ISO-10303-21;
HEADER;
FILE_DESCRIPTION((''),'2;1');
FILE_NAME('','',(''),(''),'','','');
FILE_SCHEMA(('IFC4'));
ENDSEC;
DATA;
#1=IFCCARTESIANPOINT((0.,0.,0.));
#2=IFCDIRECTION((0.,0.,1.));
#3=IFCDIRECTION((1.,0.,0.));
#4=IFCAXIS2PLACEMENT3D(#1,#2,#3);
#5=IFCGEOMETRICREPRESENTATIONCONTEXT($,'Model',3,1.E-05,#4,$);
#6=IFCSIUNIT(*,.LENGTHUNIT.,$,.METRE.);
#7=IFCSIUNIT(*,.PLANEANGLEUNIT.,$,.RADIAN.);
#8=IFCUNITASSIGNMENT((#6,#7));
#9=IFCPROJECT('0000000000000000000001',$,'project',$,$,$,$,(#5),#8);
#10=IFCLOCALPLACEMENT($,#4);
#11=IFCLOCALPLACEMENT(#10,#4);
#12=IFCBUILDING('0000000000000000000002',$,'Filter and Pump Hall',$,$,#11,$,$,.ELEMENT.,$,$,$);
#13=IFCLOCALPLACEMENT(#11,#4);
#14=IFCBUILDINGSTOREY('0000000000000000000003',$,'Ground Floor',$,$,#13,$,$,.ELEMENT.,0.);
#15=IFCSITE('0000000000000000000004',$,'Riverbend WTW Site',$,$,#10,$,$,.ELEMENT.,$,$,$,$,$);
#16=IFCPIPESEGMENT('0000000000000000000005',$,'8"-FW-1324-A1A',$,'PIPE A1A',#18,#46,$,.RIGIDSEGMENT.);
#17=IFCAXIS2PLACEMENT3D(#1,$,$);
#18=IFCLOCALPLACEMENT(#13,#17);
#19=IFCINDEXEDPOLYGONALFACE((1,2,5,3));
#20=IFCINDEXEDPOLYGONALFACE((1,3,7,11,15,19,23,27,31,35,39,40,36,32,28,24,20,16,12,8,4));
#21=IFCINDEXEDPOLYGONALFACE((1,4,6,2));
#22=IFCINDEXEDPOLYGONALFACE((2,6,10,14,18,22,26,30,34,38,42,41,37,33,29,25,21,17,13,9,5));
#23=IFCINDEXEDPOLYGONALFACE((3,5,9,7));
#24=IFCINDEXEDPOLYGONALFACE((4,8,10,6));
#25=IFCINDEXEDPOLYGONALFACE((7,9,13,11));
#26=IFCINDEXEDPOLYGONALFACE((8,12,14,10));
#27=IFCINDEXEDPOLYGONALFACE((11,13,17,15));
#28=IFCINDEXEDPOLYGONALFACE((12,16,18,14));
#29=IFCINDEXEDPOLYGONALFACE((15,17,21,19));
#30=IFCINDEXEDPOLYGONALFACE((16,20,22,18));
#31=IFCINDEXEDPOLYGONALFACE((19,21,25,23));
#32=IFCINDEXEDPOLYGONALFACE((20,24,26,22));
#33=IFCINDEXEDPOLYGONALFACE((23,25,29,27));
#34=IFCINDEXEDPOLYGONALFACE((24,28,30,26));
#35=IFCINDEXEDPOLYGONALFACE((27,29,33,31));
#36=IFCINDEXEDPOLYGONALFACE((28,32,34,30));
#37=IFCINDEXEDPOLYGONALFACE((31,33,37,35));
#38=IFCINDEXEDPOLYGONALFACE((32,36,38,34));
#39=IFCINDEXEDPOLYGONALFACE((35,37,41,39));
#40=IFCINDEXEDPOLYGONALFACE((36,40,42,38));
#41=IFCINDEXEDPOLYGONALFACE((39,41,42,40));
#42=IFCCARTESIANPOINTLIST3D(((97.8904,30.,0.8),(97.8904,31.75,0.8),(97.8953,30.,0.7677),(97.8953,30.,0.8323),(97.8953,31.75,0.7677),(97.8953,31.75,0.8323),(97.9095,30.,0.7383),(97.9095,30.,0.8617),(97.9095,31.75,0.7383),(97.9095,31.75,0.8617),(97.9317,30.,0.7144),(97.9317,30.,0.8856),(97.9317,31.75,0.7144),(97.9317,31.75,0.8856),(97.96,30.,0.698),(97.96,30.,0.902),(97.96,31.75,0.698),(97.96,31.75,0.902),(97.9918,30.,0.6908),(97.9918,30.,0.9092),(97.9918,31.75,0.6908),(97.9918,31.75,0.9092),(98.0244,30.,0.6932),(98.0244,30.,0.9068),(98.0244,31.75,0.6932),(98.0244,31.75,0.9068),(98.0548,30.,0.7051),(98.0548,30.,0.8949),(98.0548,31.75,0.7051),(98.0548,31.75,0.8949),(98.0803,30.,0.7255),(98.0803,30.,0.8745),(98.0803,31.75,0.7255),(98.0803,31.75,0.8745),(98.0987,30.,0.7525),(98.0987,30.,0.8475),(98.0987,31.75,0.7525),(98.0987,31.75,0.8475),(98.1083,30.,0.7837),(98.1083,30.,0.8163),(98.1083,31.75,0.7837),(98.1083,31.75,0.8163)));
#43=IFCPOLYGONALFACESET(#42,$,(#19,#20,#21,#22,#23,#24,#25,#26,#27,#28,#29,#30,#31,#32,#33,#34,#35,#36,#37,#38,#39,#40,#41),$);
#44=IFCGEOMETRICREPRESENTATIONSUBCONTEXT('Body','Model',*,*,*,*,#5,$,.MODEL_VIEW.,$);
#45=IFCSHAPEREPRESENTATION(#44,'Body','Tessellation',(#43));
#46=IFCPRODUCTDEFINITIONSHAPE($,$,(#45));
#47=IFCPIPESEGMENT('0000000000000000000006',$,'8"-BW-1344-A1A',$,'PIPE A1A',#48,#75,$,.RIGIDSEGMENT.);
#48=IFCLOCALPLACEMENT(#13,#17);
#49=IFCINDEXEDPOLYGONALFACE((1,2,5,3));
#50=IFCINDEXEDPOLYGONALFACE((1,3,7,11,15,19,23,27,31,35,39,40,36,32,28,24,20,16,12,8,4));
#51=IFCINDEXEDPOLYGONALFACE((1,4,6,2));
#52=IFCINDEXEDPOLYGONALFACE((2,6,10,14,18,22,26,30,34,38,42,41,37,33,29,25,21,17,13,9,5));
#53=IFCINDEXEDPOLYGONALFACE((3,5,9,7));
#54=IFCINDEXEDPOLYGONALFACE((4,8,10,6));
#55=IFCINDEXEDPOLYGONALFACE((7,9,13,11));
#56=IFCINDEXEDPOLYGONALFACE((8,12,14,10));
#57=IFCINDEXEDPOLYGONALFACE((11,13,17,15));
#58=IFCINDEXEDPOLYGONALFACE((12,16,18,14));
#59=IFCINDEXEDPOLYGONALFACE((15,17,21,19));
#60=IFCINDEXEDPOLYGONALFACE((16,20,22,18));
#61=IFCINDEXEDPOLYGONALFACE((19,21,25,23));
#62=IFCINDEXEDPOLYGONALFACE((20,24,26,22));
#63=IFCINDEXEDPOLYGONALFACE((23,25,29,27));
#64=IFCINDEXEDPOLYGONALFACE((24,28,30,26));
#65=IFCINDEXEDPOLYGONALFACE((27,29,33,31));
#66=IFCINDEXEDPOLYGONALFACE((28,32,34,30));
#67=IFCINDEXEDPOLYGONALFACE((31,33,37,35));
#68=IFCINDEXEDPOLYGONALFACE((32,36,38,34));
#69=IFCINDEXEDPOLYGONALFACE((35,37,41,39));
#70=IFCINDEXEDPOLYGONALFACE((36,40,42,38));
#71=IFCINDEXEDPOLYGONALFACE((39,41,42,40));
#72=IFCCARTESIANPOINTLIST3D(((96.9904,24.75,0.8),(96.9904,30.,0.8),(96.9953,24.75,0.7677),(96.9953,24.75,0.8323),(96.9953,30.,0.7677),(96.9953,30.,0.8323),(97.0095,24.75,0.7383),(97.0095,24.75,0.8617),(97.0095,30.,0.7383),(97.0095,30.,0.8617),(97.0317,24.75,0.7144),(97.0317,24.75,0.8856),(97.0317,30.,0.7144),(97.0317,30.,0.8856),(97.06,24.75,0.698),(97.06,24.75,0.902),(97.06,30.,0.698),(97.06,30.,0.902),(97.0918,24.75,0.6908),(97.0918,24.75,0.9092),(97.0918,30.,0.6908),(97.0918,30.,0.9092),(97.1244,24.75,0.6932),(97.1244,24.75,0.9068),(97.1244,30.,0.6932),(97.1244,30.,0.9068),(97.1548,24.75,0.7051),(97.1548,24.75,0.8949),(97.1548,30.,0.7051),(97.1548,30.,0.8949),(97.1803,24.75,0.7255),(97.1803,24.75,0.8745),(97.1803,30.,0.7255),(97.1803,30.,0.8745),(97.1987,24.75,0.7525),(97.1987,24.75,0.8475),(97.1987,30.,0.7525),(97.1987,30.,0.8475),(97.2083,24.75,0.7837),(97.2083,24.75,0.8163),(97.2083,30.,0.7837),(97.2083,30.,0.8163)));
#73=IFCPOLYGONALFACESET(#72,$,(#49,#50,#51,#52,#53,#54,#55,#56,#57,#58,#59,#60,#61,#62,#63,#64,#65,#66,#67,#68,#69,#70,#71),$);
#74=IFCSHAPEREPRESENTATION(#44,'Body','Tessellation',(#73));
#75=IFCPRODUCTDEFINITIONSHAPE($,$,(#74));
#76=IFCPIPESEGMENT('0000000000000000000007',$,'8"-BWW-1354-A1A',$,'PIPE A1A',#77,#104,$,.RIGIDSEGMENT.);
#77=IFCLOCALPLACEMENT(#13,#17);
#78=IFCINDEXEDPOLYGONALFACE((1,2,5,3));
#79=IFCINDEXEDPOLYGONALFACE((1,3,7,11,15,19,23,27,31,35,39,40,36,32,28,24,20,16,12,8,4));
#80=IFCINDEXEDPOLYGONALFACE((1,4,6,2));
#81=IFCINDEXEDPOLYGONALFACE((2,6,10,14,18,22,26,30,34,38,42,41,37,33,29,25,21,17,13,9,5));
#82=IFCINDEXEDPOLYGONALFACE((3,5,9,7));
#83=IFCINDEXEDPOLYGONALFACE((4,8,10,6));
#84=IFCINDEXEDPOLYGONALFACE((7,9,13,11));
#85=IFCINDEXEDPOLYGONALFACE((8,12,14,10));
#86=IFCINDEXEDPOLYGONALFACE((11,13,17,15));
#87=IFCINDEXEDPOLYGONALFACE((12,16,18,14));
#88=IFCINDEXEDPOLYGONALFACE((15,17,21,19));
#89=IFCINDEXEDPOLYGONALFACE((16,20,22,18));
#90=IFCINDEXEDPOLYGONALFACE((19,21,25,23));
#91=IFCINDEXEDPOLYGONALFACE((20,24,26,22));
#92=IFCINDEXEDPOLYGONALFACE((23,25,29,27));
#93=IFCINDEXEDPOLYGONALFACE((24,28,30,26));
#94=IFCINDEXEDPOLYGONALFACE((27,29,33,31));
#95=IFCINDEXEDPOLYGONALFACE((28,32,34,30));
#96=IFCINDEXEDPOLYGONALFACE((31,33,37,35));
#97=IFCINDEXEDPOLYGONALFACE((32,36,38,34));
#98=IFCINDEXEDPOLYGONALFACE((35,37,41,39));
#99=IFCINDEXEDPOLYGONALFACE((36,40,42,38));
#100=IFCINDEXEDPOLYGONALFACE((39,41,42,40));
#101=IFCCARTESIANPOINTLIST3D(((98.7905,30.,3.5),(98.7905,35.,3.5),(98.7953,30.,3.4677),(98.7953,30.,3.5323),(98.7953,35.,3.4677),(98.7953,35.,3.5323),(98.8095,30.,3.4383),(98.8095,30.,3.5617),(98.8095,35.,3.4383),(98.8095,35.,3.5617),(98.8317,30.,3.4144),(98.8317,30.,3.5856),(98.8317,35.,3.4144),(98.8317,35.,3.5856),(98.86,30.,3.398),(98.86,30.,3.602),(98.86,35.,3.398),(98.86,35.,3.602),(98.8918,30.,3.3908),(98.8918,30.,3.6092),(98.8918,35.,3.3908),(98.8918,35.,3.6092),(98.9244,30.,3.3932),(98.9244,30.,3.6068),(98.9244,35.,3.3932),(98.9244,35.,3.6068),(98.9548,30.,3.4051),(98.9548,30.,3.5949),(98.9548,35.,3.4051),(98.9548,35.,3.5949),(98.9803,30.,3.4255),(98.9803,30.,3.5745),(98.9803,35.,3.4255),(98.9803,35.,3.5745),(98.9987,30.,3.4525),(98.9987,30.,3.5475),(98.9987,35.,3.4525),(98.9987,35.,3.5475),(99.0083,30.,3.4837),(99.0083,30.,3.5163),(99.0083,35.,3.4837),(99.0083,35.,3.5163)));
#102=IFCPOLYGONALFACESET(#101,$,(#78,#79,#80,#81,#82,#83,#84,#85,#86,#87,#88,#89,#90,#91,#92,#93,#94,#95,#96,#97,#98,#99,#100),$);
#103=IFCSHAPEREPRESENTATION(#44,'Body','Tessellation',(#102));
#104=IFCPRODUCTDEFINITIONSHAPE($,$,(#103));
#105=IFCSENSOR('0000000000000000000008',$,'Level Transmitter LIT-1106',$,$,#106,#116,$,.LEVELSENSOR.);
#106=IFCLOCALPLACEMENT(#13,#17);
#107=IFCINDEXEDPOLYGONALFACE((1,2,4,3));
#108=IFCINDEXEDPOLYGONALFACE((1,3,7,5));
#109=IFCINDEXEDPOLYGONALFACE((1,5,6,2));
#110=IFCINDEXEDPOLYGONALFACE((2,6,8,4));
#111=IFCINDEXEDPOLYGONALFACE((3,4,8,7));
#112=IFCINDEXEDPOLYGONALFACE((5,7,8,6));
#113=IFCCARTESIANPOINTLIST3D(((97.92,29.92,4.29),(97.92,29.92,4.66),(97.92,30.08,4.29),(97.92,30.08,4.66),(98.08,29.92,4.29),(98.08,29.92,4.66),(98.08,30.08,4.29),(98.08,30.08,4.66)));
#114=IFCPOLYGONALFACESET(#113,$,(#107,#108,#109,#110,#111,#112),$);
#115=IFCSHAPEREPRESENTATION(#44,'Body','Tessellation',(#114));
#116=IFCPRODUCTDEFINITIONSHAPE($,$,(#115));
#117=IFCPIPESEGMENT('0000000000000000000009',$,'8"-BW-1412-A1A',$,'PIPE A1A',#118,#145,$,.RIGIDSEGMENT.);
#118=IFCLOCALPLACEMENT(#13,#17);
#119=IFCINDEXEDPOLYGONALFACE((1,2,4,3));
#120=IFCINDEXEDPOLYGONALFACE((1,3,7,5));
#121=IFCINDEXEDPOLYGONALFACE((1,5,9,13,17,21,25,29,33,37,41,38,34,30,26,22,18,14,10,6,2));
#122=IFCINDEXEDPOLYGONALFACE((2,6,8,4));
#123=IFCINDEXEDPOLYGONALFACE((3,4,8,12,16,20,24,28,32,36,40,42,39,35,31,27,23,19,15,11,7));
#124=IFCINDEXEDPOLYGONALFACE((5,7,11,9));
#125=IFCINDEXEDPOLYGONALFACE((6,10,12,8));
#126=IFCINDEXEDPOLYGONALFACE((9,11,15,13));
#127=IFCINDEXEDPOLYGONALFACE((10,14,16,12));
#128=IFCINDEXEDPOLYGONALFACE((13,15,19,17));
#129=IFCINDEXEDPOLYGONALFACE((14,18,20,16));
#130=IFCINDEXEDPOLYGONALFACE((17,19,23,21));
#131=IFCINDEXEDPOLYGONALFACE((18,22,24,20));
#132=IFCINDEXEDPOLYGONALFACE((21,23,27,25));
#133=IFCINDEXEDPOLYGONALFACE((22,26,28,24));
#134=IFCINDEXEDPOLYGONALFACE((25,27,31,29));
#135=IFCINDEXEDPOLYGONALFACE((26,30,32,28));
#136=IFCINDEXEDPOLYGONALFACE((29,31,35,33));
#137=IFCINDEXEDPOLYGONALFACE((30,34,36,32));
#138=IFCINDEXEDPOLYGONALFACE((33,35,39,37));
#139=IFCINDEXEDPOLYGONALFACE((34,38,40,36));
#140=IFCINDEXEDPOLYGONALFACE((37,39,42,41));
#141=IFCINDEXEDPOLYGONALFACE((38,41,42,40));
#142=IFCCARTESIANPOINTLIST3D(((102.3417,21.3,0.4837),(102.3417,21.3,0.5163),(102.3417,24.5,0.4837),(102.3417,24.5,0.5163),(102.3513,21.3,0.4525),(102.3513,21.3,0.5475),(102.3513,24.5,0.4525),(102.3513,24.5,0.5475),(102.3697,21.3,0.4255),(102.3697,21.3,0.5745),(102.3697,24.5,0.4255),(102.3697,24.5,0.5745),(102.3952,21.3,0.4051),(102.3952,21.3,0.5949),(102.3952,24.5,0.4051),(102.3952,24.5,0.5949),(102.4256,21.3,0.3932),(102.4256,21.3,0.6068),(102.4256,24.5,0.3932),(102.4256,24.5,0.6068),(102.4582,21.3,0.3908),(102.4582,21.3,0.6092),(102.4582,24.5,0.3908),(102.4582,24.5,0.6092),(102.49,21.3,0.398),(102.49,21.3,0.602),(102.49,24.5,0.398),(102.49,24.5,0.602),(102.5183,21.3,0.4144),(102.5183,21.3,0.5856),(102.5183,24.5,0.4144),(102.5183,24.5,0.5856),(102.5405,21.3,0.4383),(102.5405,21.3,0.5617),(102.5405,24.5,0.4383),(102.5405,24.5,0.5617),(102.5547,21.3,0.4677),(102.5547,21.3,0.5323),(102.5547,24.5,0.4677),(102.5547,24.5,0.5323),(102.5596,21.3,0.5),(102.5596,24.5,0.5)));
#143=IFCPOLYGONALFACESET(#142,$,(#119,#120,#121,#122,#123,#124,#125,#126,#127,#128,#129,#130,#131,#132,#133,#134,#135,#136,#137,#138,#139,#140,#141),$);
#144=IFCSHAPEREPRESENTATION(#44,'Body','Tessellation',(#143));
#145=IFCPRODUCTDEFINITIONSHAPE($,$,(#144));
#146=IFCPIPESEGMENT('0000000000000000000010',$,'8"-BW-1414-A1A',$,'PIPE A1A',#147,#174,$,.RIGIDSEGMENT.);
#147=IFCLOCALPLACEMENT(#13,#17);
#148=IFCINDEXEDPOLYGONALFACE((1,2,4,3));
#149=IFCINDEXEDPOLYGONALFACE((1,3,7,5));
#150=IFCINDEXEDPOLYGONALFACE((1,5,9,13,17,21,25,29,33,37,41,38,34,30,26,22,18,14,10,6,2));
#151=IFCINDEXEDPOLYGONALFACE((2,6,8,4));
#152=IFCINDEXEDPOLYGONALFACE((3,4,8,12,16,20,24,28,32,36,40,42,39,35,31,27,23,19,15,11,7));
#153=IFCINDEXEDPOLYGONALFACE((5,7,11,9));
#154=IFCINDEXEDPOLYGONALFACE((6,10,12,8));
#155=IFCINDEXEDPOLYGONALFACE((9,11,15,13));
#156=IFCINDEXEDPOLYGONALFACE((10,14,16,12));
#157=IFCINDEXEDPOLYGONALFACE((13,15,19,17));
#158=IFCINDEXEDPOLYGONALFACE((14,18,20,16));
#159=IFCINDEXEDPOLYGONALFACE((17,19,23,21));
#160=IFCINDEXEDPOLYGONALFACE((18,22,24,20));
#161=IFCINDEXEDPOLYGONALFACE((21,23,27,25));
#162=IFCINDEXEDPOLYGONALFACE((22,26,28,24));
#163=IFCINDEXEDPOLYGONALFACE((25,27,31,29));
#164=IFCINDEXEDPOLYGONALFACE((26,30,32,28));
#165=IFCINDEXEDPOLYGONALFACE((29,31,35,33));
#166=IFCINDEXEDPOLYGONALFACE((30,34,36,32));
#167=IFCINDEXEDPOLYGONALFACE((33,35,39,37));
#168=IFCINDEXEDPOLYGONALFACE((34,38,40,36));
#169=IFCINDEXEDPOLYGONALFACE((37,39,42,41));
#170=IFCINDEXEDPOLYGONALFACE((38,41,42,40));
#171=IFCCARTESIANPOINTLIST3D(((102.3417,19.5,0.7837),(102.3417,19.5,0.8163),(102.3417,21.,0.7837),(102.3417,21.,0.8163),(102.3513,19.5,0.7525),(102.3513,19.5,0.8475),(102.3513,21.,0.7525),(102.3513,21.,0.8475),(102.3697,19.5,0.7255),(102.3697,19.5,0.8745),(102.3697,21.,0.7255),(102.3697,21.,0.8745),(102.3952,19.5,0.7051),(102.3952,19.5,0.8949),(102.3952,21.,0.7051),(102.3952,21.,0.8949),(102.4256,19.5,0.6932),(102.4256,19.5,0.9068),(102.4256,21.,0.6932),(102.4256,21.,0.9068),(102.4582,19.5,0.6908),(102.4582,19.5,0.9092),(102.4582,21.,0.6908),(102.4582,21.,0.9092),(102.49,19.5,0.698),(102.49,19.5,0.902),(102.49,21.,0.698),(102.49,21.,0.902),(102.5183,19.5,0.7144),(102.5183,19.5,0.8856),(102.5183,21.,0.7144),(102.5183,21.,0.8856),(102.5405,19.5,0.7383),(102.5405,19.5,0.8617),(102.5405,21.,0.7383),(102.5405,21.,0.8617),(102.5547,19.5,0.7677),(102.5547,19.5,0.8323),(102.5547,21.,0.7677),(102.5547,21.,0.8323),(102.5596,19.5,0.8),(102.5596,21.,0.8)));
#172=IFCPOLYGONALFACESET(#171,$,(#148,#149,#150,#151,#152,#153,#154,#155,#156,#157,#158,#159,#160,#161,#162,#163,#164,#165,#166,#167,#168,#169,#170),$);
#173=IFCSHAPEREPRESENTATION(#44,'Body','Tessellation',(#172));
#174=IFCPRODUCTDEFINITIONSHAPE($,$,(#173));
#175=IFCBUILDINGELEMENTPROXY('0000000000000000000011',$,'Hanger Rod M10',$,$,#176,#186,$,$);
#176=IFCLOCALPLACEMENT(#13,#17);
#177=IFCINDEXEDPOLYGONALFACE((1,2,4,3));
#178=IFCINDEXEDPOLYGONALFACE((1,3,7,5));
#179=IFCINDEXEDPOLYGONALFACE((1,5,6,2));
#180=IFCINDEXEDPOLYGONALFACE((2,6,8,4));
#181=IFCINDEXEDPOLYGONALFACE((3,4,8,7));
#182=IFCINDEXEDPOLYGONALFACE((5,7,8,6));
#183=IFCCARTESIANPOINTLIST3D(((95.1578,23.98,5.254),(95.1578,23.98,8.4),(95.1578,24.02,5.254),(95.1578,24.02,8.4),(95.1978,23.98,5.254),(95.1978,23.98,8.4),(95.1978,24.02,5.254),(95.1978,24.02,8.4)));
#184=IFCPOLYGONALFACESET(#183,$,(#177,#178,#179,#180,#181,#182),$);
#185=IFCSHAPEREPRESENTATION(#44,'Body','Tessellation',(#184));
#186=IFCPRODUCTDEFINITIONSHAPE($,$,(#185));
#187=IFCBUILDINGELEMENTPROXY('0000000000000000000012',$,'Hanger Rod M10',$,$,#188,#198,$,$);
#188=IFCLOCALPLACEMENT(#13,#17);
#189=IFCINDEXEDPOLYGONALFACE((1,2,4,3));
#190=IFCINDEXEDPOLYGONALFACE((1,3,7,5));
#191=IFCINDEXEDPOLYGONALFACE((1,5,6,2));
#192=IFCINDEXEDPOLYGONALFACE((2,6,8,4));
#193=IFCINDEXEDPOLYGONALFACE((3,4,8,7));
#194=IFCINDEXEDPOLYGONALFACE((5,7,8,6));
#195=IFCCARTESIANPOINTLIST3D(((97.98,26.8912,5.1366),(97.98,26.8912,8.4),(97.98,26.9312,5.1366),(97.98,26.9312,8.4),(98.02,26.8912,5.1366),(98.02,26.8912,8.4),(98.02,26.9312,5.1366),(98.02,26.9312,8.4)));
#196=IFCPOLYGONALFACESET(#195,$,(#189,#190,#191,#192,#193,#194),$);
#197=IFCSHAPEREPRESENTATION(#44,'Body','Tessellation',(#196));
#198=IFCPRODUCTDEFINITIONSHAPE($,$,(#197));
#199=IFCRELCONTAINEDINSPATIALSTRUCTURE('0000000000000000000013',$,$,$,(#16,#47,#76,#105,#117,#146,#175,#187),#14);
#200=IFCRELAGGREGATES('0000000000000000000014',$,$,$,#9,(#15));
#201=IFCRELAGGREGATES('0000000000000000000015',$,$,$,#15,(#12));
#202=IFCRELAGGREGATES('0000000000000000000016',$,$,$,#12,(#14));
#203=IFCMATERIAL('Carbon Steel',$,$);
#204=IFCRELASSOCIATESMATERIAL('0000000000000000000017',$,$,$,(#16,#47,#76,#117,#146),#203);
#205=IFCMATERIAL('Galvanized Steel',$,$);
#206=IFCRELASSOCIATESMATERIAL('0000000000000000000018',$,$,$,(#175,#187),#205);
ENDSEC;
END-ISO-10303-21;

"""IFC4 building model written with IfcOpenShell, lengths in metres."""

from ifc_helpers import new_model, si_unit, frame, origin_with_axes, origin_2d, place, context, subcontext, project, spatial, rectangle, circle, extrude, material, element, save


model = new_model("IFC4")

# Units and contexts
model_context = context("Model", 3, precision=1e-05, world=origin_with_axes())
body_context = subcontext(model_context, "Body", "Model", "MODEL_VIEW")
ifc_project = project(units=[si_unit("LENGTHUNIT", "METRE"), si_unit("PLANEANGLEUNIT", "RADIAN")], contexts=[model_context])

# Site, building, storey
site_placement = place(None, origin_with_axes())
site = spatial("IfcSite", under=ifc_project, at=site_placement, Name="Riverbend WTW Site", CompositionType="ELEMENT")
building_placement = place(site_placement, origin_with_axes())
building = spatial("IfcBuilding", under=site, at=building_placement, Name="Filter and Pump Hall", CompositionType="ELEMENT")
storey_placement = place(building_placement, origin_with_axes())
storey = spatial("IfcBuildingStorey", under=building, at=storey_placement, Name="Ground Floor", CompositionType="ELEMENT", Elevation=0.0)

# Shared definitions
ifc_material_1 = material(Name="Carbon Steel")

# Pipe segments
pipe_segment_1_placement = place(None, frame((98.0, 30.0, 0.8), z_axis=(0.0, 0.0, 1.0), x_axis=(1.0, 0.0, 0.0)))
element("IfcPipeSegment", 1, at=pipe_segment_1_placement, inside=storey, material=ifc_material_1, Name="8\"-FW-1324-A1A", ObjectType="PIPE A1A", PredefinedType="RIGIDSEGMENT", context=body_context, shape_type="SweptSolid", body=[
    extrude(circle(Radius=0.1095, at=origin_2d()), frame((0.0, 0.0, 0.0), z_axis=(0.0, 1.0, 0.0), x_axis=(-1.0, 0.0, 0.0)), (0.0, 0.0, 1.0), 1.75),
])
pipe_segment_2_placement = place(None, frame((97.1, 24.75, 0.8), z_axis=(0.0, 0.0, 1.0), x_axis=(1.0, 0.0, 0.0)))
element("IfcPipeSegment", 2, at=pipe_segment_2_placement, inside=storey, material=ifc_material_1, Name="8\"-BW-1344-A1A", ObjectType="PIPE A1A", PredefinedType="RIGIDSEGMENT", context=body_context, shape_type="SweptSolid", body=[
    extrude(circle(Radius=0.1095, at=origin_2d()), frame((0.0, 0.0, 0.0), z_axis=(0.0, 1.0, 0.0), x_axis=(-1.0, 0.0, 0.0)), (0.0, 0.0, 1.0), 5.25),
])
pipe_segment_3_placement = place(None, frame((98.9, 30.0, 3.5), z_axis=(0.0, 0.0, 1.0), x_axis=(1.0, 0.0, 0.0)))
element("IfcPipeSegment", 3, at=pipe_segment_3_placement, inside=storey, material=ifc_material_1, Name="8\"-BWW-1354-A1A", ObjectType="PIPE A1A", PredefinedType="RIGIDSEGMENT", context=body_context, shape_type="SweptSolid", body=[
    extrude(circle(Radius=0.1095, at=origin_2d()), frame((0.0, 0.0, 0.0), z_axis=(0.0, 1.0, 0.0), x_axis=(-1.0, 0.0, 0.0)), (0.0, 0.0, 1.0), 5.0),
])

# Sensor
sensor_1_placement = place(None, frame((98.0, 30.0, 4.475), z_axis=(0.0, 0.0, 1.0), x_axis=(1.0, 0.0, 0.0)))
element("IfcSensor", 4, at=sensor_1_placement, inside=storey, Name="Level Transmitter LIT-1106", PredefinedType="LEVELSENSOR", context=body_context, shape_type="SweptSolid", body=[
    extrude(rectangle(XDim=0.16, YDim=0.16, at=origin_2d()), frame((0.0, 0.0, -0.185), z_axis=(0.0, 0.0, 1.0), x_axis=(1.0, 0.0, 0.0)), (0.0, 0.0, 1.0), 0.37),
])

# Pipe segments
pipe_segment_4_placement = place(None, frame((102.45, 24.5, 0.5), z_axis=(0.0, 0.0, 1.0), x_axis=(1.0, 0.0, 0.0)))
element("IfcPipeSegment", 5, at=pipe_segment_4_placement, inside=storey, material=ifc_material_1, Name="8\"-BW-1412-A1A", ObjectType="PIPE A1A", PredefinedType="RIGIDSEGMENT", context=body_context, shape_type="SweptSolid", body=[
    extrude(circle(Radius=0.1095, at=origin_2d()), frame((0.0, 0.0, 0.0), z_axis=(0.0, -1.0, 0.0), x_axis=(1.0, 0.0, 0.0)), (0.0, 0.0, 1.0), 3.2),
])
pipe_segment_5_placement = place(None, frame((102.45, 21.0, 0.8), z_axis=(0.0, 0.0, 1.0), x_axis=(1.0, 0.0, 0.0)))
element("IfcPipeSegment", 6, at=pipe_segment_5_placement, inside=storey, material=ifc_material_1, Name="8\"-BW-1414-A1A", ObjectType="PIPE A1A", PredefinedType="RIGIDSEGMENT", context=body_context, shape_type="SweptSolid", body=[
    extrude(circle(Radius=0.1095, at=origin_2d()), frame((0.0, 0.0, 0.0), z_axis=(0.0, -1.0, 0.0), x_axis=(1.0, 0.0, 0.0)), (0.0, 0.0, 1.0), 1.5),
])

# Building element proxies
ifc_material_2 = material(Name="Galvanized Steel")
proxy_1_placement = place(None, frame((95.1778, 24.0, 6.827), z_axis=(0.0, 0.0, 1.0), x_axis=(1.0, 0.0, 0.0)))
element("IfcBuildingElementProxy", 7, at=proxy_1_placement, inside=storey, material=ifc_material_2, Name="Hanger Rod M10", context=body_context, shape_type="SweptSolid", body=[
    extrude(rectangle(XDim=0.04, YDim=0.04, at=origin_2d()), frame((0.0, 0.0, -1.573), z_axis=(0.0, 0.0, 1.0), x_axis=(1.0, 0.0, 0.0)), (0.0, 0.0, 1.0), 3.146),
])
proxy_2_placement = place(None, frame((98.0, 26.9112, 6.7683), z_axis=(0.0, 0.0, 1.0), x_axis=(1.0, 0.0, 0.0)))
element("IfcBuildingElementProxy", 8, at=proxy_2_placement, inside=storey, material=ifc_material_2, Name="Hanger Rod M10", context=body_context, shape_type="SweptSolid", body=[
    extrude(rectangle(XDim=0.04, YDim=0.04, at=origin_2d()), frame((0.0, 0.0, -1.6317), z_axis=(0.0, 0.0, 1.0), x_axis=(1.0, 0.0, 0.0)), (0.0, 0.0, 1.0), 3.2635),
])

save(model, "model.ifc")
